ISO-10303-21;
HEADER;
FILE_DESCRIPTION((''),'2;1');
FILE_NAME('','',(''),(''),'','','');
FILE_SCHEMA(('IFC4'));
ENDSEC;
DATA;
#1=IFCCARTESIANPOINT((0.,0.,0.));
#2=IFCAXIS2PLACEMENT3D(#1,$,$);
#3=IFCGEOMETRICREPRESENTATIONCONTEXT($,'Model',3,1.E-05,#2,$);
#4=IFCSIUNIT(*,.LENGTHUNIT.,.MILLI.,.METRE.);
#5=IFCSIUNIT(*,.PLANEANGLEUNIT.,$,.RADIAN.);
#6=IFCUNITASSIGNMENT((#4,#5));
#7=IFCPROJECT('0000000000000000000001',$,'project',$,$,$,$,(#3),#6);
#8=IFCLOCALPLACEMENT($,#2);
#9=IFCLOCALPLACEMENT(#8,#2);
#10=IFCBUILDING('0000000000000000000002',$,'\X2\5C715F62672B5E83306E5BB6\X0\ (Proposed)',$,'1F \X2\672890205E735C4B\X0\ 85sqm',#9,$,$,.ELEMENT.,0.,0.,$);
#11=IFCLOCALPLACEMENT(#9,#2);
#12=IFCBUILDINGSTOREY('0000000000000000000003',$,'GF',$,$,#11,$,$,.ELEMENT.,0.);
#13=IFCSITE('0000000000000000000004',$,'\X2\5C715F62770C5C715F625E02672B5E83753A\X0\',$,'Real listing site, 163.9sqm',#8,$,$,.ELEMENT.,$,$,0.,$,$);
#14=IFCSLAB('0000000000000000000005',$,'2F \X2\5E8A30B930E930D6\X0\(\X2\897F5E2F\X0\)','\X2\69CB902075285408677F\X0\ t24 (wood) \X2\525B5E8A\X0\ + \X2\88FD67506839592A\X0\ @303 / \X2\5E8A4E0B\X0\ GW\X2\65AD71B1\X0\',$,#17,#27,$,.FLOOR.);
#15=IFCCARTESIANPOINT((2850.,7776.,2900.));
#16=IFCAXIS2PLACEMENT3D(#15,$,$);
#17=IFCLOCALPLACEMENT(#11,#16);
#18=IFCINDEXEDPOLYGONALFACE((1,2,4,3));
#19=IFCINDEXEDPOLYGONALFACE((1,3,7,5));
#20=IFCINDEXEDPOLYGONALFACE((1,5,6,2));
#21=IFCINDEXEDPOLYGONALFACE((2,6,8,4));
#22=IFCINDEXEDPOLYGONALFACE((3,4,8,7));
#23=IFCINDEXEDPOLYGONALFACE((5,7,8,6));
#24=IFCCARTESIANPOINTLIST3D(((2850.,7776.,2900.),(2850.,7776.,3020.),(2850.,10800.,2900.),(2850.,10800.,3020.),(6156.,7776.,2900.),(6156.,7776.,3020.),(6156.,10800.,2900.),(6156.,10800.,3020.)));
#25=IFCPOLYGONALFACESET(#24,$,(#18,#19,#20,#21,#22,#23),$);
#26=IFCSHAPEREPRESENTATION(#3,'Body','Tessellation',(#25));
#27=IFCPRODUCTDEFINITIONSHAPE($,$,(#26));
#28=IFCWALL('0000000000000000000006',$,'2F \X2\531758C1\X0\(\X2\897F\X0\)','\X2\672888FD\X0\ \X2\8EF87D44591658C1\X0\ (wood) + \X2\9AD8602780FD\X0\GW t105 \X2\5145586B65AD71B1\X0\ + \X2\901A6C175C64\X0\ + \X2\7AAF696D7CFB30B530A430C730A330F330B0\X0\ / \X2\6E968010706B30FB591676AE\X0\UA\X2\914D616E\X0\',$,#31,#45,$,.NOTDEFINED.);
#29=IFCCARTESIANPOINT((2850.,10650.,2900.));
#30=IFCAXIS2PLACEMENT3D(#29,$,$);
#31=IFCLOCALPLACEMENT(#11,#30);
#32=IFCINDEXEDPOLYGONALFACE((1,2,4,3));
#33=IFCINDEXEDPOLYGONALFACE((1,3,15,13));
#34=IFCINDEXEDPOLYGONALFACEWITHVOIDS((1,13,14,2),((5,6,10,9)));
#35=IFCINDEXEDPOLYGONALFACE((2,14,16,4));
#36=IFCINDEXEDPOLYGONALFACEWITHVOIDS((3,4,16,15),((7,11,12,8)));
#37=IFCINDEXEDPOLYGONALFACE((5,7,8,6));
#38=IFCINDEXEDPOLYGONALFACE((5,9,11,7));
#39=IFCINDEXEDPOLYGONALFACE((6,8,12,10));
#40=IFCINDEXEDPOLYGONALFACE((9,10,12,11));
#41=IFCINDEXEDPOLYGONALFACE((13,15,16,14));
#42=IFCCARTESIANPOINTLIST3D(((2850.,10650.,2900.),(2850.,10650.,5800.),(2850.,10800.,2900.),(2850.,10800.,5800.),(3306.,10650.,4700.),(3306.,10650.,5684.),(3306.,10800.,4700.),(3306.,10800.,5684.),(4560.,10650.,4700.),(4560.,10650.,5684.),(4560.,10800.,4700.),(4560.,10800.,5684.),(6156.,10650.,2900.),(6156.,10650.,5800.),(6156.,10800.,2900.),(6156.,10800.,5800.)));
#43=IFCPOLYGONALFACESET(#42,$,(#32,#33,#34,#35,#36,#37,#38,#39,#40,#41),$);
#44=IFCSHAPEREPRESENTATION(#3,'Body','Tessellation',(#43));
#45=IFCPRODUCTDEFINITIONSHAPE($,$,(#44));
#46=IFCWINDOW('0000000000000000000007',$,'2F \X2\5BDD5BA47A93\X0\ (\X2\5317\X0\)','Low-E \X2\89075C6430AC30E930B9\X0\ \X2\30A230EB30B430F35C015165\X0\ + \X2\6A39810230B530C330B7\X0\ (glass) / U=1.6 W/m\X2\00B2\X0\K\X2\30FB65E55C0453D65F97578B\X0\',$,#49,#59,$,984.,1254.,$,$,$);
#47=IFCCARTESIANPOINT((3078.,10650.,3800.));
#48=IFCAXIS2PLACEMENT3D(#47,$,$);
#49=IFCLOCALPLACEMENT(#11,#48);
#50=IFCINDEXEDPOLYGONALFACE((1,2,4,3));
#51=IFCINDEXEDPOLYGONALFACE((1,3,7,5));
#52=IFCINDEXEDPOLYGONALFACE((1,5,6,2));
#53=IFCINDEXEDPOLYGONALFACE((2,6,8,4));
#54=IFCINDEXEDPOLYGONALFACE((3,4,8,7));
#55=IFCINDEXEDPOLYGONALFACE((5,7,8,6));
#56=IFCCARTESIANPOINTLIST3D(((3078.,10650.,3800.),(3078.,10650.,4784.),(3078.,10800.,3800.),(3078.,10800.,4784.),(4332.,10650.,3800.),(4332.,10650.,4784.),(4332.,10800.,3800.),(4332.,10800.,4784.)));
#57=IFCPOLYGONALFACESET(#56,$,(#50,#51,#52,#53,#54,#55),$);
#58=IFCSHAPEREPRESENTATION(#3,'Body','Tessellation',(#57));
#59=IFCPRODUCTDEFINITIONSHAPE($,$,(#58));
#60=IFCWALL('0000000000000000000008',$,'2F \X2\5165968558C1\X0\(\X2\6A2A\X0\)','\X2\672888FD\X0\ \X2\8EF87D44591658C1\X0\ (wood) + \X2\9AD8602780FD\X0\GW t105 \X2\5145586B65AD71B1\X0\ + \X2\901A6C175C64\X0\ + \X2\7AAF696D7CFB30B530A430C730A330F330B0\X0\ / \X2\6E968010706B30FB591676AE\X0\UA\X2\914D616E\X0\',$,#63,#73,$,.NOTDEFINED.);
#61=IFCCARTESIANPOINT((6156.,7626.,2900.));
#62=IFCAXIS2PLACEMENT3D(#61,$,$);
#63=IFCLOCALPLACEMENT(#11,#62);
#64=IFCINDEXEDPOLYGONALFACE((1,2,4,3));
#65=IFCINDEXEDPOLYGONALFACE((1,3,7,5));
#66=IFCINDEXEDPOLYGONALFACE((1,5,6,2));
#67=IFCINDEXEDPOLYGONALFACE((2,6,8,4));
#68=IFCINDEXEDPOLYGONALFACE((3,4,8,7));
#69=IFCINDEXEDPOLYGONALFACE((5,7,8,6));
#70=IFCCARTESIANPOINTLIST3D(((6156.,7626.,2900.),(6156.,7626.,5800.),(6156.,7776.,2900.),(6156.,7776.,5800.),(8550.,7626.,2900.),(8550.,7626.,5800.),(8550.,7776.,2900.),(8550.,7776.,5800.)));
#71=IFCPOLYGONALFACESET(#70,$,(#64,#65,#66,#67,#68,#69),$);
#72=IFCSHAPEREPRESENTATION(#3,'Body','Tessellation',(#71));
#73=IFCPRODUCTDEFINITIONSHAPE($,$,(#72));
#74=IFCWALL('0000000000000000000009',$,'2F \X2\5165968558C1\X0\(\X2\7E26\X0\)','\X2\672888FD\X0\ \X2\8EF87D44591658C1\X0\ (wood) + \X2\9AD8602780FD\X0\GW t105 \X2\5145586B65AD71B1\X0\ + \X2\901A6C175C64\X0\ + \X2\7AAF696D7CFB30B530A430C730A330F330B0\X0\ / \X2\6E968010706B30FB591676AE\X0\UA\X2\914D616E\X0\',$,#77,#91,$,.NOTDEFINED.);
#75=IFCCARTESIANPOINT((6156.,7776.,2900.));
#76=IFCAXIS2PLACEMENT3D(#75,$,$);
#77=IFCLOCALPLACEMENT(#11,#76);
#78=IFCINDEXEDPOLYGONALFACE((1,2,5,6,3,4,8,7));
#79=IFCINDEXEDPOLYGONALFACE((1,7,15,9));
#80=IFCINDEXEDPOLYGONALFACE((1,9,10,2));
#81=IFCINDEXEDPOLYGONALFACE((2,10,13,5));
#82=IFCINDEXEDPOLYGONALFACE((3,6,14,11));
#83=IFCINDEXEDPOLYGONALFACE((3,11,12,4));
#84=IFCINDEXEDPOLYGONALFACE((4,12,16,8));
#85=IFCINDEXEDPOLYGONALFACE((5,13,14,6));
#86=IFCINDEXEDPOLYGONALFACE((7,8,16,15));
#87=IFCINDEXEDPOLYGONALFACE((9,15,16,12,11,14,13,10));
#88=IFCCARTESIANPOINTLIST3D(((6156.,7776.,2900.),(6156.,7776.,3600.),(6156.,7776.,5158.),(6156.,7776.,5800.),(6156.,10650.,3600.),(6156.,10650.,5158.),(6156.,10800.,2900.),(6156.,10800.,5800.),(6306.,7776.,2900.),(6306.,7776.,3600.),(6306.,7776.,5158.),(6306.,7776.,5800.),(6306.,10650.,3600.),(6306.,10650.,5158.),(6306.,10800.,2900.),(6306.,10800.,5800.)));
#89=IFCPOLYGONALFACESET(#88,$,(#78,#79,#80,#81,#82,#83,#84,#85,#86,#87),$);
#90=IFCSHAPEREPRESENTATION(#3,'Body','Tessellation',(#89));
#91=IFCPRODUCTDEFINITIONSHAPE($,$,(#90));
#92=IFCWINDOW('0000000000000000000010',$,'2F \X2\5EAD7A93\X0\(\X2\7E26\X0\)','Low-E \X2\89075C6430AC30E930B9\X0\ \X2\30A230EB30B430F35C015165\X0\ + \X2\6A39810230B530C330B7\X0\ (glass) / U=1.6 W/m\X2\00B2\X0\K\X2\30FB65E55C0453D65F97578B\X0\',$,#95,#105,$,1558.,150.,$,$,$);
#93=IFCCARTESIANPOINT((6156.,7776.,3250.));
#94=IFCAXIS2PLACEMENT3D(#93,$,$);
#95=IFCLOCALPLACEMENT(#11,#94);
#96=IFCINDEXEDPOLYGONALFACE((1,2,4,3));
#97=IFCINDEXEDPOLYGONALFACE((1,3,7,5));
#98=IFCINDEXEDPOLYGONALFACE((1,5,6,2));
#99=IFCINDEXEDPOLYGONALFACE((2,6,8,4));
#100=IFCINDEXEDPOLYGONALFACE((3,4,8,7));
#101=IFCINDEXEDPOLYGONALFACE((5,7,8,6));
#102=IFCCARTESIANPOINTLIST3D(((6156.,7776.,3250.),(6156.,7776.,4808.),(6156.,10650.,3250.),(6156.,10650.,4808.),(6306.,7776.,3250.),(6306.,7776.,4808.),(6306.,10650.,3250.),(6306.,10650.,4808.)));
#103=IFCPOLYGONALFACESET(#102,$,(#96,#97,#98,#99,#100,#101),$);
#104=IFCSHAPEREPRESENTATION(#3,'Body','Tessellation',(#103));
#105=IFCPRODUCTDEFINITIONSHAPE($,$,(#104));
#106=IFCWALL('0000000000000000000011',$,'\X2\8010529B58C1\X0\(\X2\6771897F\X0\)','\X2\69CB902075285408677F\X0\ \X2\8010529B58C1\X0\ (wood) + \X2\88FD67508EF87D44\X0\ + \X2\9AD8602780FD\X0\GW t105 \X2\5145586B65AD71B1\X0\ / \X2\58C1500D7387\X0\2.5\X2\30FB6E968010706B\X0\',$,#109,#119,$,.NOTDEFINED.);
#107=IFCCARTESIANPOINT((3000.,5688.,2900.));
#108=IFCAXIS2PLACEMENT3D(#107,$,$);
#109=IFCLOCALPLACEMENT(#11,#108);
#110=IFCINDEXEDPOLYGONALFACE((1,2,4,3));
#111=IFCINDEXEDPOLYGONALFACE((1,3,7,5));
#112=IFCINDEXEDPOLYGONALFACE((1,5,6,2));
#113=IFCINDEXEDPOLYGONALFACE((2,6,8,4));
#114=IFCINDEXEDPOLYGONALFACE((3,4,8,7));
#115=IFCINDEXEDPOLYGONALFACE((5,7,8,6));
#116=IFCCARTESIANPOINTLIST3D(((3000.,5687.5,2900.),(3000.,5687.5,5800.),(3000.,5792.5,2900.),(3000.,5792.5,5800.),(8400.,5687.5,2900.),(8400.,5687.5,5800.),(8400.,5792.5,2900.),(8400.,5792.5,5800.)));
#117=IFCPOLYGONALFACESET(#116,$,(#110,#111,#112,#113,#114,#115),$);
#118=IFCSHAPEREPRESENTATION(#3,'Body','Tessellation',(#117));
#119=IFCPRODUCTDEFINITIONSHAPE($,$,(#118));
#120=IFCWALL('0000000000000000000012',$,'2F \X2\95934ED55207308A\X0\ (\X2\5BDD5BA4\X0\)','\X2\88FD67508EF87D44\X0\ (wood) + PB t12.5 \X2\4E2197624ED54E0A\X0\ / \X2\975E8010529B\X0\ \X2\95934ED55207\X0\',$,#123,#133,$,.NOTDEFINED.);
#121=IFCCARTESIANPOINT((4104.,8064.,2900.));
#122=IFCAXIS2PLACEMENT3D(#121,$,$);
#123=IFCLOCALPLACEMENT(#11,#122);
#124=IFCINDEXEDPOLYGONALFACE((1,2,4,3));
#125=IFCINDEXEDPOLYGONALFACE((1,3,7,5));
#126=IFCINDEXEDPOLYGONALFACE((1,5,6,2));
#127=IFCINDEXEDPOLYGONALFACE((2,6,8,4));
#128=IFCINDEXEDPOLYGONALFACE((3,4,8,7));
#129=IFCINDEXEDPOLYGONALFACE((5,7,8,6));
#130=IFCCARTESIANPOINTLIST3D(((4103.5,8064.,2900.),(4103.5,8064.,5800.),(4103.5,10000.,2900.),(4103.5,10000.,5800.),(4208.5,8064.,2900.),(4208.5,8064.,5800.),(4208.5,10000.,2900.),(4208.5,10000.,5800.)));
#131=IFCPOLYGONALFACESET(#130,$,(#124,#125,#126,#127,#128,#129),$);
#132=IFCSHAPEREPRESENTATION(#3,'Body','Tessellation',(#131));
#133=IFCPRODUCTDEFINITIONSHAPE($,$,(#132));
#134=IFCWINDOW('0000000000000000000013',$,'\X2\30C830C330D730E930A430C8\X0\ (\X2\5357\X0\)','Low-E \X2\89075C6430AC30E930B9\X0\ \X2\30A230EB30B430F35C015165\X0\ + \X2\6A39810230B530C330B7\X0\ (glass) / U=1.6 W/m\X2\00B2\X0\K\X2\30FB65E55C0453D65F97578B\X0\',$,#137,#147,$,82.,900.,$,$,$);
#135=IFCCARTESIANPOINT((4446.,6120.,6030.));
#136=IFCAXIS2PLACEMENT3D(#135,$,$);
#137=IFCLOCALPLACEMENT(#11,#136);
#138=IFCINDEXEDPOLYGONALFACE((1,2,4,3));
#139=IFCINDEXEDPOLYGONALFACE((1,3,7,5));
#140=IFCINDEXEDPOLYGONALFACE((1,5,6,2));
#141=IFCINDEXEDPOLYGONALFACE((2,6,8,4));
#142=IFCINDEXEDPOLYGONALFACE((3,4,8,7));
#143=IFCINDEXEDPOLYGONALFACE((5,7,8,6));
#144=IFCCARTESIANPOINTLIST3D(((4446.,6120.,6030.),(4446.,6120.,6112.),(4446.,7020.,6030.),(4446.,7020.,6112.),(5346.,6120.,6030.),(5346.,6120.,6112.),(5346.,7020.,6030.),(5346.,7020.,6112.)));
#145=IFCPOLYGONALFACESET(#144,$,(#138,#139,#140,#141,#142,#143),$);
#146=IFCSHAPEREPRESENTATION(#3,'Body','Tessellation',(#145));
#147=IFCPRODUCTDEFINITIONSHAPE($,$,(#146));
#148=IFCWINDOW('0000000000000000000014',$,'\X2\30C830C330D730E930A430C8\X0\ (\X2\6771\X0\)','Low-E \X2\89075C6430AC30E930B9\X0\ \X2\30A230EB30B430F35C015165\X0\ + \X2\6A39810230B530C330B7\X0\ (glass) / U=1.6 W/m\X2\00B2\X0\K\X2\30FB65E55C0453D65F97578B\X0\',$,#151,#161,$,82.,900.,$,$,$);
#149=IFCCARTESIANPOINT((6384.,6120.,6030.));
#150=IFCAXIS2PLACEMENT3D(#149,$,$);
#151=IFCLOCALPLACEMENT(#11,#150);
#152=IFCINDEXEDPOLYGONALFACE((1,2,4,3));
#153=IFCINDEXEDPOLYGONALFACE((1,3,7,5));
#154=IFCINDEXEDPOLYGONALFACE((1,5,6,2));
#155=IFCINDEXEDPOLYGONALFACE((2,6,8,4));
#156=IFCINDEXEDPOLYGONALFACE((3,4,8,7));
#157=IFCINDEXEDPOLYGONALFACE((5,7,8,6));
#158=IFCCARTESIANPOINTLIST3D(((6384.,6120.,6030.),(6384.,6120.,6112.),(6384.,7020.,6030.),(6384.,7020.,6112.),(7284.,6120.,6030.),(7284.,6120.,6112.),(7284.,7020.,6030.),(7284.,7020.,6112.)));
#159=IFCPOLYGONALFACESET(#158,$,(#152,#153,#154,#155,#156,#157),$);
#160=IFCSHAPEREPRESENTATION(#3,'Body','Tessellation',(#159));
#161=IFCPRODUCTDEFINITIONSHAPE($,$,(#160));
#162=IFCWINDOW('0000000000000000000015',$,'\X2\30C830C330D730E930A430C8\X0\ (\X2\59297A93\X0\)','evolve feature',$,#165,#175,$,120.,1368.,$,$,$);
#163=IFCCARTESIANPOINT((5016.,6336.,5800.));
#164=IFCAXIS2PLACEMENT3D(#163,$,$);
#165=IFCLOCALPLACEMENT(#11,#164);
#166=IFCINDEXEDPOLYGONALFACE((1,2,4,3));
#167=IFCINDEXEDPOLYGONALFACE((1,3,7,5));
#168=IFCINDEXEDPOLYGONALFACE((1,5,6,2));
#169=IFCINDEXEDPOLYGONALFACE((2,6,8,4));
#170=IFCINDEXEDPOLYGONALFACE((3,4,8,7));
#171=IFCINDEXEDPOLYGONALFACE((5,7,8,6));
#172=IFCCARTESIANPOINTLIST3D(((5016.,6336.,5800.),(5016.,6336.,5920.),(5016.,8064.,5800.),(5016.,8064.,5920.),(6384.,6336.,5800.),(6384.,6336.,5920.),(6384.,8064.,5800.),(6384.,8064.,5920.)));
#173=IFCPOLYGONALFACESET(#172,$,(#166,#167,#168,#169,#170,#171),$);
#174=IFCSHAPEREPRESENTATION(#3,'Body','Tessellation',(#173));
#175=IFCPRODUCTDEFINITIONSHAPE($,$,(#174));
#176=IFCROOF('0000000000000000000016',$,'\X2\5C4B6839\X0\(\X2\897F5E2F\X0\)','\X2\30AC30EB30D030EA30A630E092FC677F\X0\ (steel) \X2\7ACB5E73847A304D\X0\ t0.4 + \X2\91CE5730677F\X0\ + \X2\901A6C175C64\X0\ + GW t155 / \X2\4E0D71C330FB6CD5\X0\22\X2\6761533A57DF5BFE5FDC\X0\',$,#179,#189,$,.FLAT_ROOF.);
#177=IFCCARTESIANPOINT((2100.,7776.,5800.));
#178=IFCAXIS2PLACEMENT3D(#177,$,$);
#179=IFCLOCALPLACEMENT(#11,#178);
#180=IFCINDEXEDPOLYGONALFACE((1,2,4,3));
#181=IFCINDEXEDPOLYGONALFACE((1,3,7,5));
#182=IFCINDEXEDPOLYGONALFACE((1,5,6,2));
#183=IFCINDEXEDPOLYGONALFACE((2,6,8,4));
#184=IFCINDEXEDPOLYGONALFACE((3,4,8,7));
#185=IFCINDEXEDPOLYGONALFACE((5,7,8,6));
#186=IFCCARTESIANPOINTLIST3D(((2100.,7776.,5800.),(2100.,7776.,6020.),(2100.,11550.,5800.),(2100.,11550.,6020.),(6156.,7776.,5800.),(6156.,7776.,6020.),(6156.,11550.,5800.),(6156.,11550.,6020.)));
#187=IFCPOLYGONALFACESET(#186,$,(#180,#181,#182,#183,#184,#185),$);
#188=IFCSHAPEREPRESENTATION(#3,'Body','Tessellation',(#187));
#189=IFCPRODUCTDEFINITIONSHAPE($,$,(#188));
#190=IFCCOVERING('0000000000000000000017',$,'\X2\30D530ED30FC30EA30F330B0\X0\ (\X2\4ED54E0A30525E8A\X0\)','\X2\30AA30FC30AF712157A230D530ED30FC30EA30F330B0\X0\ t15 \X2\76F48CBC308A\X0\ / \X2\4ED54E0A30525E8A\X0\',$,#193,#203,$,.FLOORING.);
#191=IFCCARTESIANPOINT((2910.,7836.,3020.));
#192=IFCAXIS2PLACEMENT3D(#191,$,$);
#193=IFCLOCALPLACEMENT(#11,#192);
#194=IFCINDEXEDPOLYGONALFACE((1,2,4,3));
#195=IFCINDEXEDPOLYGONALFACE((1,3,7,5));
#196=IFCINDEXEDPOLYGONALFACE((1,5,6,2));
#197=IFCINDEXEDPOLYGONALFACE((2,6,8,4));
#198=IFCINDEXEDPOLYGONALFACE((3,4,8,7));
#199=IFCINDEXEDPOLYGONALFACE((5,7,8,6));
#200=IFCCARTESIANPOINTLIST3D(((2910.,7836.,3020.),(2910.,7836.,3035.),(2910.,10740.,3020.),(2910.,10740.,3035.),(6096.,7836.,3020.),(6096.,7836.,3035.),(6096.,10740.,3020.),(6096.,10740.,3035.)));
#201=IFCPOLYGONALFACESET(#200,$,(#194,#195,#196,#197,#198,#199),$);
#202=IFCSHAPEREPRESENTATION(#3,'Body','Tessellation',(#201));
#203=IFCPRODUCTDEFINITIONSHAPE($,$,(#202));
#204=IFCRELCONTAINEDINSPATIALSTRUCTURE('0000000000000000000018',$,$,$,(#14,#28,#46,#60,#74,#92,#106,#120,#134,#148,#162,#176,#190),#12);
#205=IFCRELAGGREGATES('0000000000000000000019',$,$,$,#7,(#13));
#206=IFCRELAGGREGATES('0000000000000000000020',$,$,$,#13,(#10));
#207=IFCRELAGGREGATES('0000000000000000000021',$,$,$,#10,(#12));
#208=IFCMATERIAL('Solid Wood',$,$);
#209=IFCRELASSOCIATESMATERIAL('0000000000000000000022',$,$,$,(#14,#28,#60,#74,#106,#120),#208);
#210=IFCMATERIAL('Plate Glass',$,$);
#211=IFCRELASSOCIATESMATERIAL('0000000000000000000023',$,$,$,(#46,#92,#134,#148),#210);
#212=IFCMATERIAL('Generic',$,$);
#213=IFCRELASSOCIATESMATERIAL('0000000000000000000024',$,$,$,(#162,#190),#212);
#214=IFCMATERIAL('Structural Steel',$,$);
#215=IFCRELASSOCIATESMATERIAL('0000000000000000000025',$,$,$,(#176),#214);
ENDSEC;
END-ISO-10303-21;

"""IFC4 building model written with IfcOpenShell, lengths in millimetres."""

from ifc_helpers import new_model, si_unit, frame, frame_2d, origin, place, context, project, spatial, rectangle, extrude, material, element, fill, save


model = new_model("IFC4")

# Units and contexts
model_context = context("Model", 3, precision=1e-05, world=origin())
ifc_project = project(units=[si_unit("LENGTHUNIT", "METRE", prefix="MILLI"), si_unit("PLANEANGLEUNIT", "RADIAN")], contexts=[model_context])

# Site, building, storey
site_placement = place(None, origin())
site = spatial("IfcSite", under=ifc_project, at=site_placement, Name="山形県山形市末広町", ObjectType="Real listing site, 163.9sqm", CompositionType="ELEMENT", RefElevation=0.0)
building_placement = place(site_placement, origin())
building = spatial("IfcBuilding", under=site, at=building_placement, Name="山形末広の家 (Proposed)", ObjectType="1F 木造平屋 85sqm", CompositionType="ELEMENT", ElevationOfRefHeight=0.0, ElevationOfTerrain=0.0)
storey_placement = place(building_placement, origin())
storey = spatial("IfcBuildingStorey", under=building, at=storey_placement, Name="GF", CompositionType="ELEMENT", Elevation=0.0)

# Slab
ifc_material_1 = material(Name="Solid Wood")
slab_placement = place(storey_placement, frame((2850.0, 7776.0, 2900.0)))
element("IfcSlab", 1, at=slab_placement, inside=storey, material=ifc_material_1, Name="2F 床スラブ(西帯)", Description="構造用合板 t24 (wood) 剛床 + 製材根太 @303 / 床下 GW断熱", PredefinedType="FLOOR", context=model_context, shape_type="SweptSolid", body=[
    extrude(rectangle(XDim=3306.0, YDim=3024.0, at=frame_2d((1653.0, 1512.0))), frame((2850.0, 7776.0, 2900.0)), (0.0, 0.0, 1.0), 120.0),
])

# Wall, opening, window
wall_1_placement = place(storey_placement, frame((2850.0, 10650.0, 2900.0)))
wall_1 = element("IfcWall", 2, at=wall_1_placement, inside=storey, material=ifc_material_1, Name="2F 北壁(西)", Description="木製 軸組外壁 (wood) + 高性能GW t105 充填断熱 + 通気層 + 窯業系サイディング / 準耐火・外皮UA配慮", PredefinedType="NOTDEFINED", context=model_context, shape_type="SweptSolid", body=[
    extrude(rectangle(XDim=3306.0, YDim=150.0, at=frame_2d((1653.0, 75.0))), frame((2850.0, 10650.0, 2900.0)), (0.0, 0.0, 1.0), 2900.0),
])
opening_1_placement = place(storey_placement, frame((3078.0, 10650.0, 3800.0)))
opening_1 = element("IfcOpeningElement", 3, at=opening_1_placement, cuts=wall_1, PredefinedType="NOTDEFINED", context=model_context, shape_type="SweptSolid", body=[
    extrude(rectangle(XDim=1254.0, YDim=150.0, at=frame_2d((627.0, 75.0))), frame((3078.0, 10650.0, 3800.0)), (0.0, 0.0, 1.0), 984.0),
])
ifc_material_2 = material(Name="Plate Glass")
window_1_placement = place(storey_placement, frame((3078.0, 10650.0, 3800.0)))
window_1 = element("IfcWindow", 4, at=window_1_placement, inside=storey, material=ifc_material_2, Name="2F 寝室窓 (北)", Description="Low-E 複層ガラス アルゴン封入 + 樹脂サッシ (glass) / U=1.6 W/m²K・日射取得型", OverallHeight=984.0, OverallWidth=1254.0, context=model_context, shape_type="SweptSolid", body=[
    extrude(rectangle(XDim=1254.0, YDim=150.0, at=frame_2d((627.0, 75.0))), frame((3078.0, 10650.0, 3800.0)), (0.0, 0.0, 1.0), 984.0),
])
fill(opening_1, window_1)

# Wall
wall_2_placement = place(storey_placement, frame((6156.0, 7626.0, 2900.0)))
element("IfcWall", 5, at=wall_2_placement, inside=storey, material=ifc_material_1, Name="2F 入隅壁(横)", Description="木製 軸組外壁 (wood) + 高性能GW t105 充填断熱 + 通気層 + 窯業系サイディング / 準耐火・外皮UA配慮", PredefinedType="NOTDEFINED", context=model_context, shape_type="SweptSolid", body=[
    extrude(rectangle(XDim=2394.0, YDim=150.0, at=frame_2d((1197.0, 75.0))), frame((6156.0, 7626.0, 2900.0)), (0.0, 0.0, 1.0), 2900.0),
])

# Wall, opening, window
wall_3_placement = place(storey_placement, frame((6156.0, 7776.0, 2900.0)))
wall_3 = element("IfcWall", 6, at=wall_3_placement, inside=storey, material=ifc_material_1, Name="2F 入隅壁(縦)", Description="木製 軸組外壁 (wood) + 高性能GW t105 充填断熱 + 通気層 + 窯業系サイディング / 準耐火・外皮UA配慮", PredefinedType="NOTDEFINED", context=model_context, shape_type="SweptSolid", body=[
    extrude(rectangle(XDim=150.0, YDim=3024.0, at=frame_2d((75.0, 1512.0))), frame((6156.0, 7776.0, 2900.0)), (0.0, 0.0, 1.0), 2900.0),
])
opening_2_placement = place(storey_placement, frame((6156.0, 7776.0, 3250.0)))
opening_2 = element("IfcOpeningElement", 7, at=opening_2_placement, cuts=wall_3, PredefinedType="NOTDEFINED", context=model_context, shape_type="SweptSolid", body=[
    extrude(rectangle(XDim=150.0, YDim=2874.0, at=frame_2d((75.0, 1437.0))), frame((6156.0, 7776.0, 3250.0)), (0.0, 0.0, 1.0), 1558.0),
])
window_2_placement = place(storey_placement, frame((6156.0, 7776.0, 3250.0)))
window_2 = element("IfcWindow", 8, at=window_2_placement, inside=storey, material=ifc_material_2, Name="2F 庭窓(縦)", Description="Low-E 複層ガラス アルゴン封入 + 樹脂サッシ (glass) / U=1.6 W/m²K・日射取得型", OverallHeight=1558.0, OverallWidth=150.0, context=model_context, shape_type="SweptSolid", body=[
    extrude(rectangle(XDim=150.0, YDim=2874.0, at=frame_2d((75.0, 1437.0))), frame((6156.0, 7776.0, 3250.0)), (0.0, 0.0, 1.0), 1558.0),
])
fill(opening_2, window_2)

# Walls
wall_4_placement = place(storey_placement, frame((3000.0, 5688.0, 2900.0)))
element("IfcWall", 9, at=wall_4_placement, inside=storey, material=ifc_material_1, Name="耐力壁(東西)", Description="構造用合板 耐力壁 (wood) + 製材軸組 + 高性能GW t105 充填断熱 / 壁倍率2.5・準耐火", PredefinedType="NOTDEFINED", context=model_context, shape_type="SweptSolid", body=[
    extrude(rectangle(XDim=5400.0, YDim=105.0, at=frame_2d((2700.0, 52.0))), frame((3000.0, 5688.0, 2900.0)), (0.0, 0.0, 1.0), 2900.0),
])
wall_5_placement = place(storey_placement, frame((4104.0, 8064.0, 2900.0)))
element("IfcWall", 10, at=wall_5_placement, inside=storey, material=ifc_material_1, Name="2F 間仕切り (寝室)", Description="製材軸組 (wood) + PB t12.5 両面仕上 / 非耐力 間仕切", PredefinedType="NOTDEFINED", context=model_context, shape_type="SweptSolid", body=[
    extrude(rectangle(XDim=105.0, YDim=1936.0, at=frame_2d((52.0, 968.0))), frame((4104.0, 8064.0, 2900.0)), (0.0, 0.0, 1.0), 2900.0),
])

# Windows
window_3_placement = place(storey_placement, frame((4446.0, 6120.0, 6030.0)))
element("IfcWindow", 11, at=window_3_placement, inside=storey, material=ifc_material_2, Name="トップライト (南)", Description="Low-E 複層ガラス アルゴン封入 + 樹脂サッシ (glass) / U=1.6 W/m²K・日射取得型", OverallHeight=82.0, OverallWidth=900.0, context=model_context, shape_type="SweptSolid", body=[
    extrude(rectangle(XDim=900.0, YDim=900.0, at=frame_2d((450.0, 450.0))), frame((4446.0, 6120.0, 6030.0)), (0.0, 0.0, 1.0), 82.0),
])
window_4_placement = place(storey_placement, frame((6384.0, 6120.0, 6030.0)))
element("IfcWindow", 12, at=window_4_placement, inside=storey, material=ifc_material_2, Name="トップライト (東)", Description="Low-E 複層ガラス アルゴン封入 + 樹脂サッシ (glass) / U=1.6 W/m²K・日射取得型", OverallHeight=82.0, OverallWidth=900.0, context=model_context, shape_type="SweptSolid", body=[
    extrude(rectangle(XDim=900.0, YDim=900.0, at=frame_2d((450.0, 450.0))), frame((6384.0, 6120.0, 6030.0)), (0.0, 0.0, 1.0), 82.0),
])
ifc_material_3 = material(Name="Generic")
window_5_placement = place(storey_placement, frame((5016.0, 6336.0, 5800.0)))
element("IfcWindow", 13, at=window_5_placement, inside=storey, material=ifc_material_3, Name="トップライト (天窓)", Description="evolve feature", OverallHeight=120.0, OverallWidth=1368.0, context=model_context, shape_type="SweptSolid", body=[
    extrude(rectangle(XDim=1368.0, YDim=1728.0, at=frame_2d((684.0, 864.0))), frame((5016.0, 6336.0, 5800.0)), (0.0, 0.0, 1.0), 120.0),
])

# Roof
ifc_material_4 = material(Name="Structural Steel")
for number, where, name in (
    (14, (2100.0, 7776.0, 5800.0), "屋根(西帯)"),
):
    element("IfcRoof", number, at=place(storey_placement, frame(where)), inside=storey, material=ifc_material_4, Name=name, Description="ガルバリウム鋼板 (steel) 立平葺き t0.4 + 野地板 + 通気層 + GW t155 / 不燃・法22条区域対応", PredefinedType="FLAT_ROOF", context=model_context, shape_type="SweptSolid", body=[
        extrude(rectangle(XDim=4056.0, YDim=3774.0, at=frame_2d((2028.0, 1887.0))), frame((2100.0, 7776.0, 5800.0)), (0.0, 0.0, 1.0), 220.0),
    ])

# Covering
covering_placement = place(storey_placement, frame((2910.0, 7836.0, 3020.0)))
element("IfcCovering", 15, at=covering_placement, inside=storey, material=ifc_material_3, Name="フローリング (仕上げ床)", Description="オーク無垢フローリング t15 直貼り / 仕上げ床", PredefinedType="FLOORING", context=model_context, shape_type="SweptSolid", body=[
    extrude(rectangle(XDim=3186.0, YDim=2904.0, at=frame_2d((1593.0, 1452.0))), frame((2910.0, 7836.0, 3020.0)), (0.0, 0.0, 1.0), 15.0),
])

save(model, "model.ifc")
